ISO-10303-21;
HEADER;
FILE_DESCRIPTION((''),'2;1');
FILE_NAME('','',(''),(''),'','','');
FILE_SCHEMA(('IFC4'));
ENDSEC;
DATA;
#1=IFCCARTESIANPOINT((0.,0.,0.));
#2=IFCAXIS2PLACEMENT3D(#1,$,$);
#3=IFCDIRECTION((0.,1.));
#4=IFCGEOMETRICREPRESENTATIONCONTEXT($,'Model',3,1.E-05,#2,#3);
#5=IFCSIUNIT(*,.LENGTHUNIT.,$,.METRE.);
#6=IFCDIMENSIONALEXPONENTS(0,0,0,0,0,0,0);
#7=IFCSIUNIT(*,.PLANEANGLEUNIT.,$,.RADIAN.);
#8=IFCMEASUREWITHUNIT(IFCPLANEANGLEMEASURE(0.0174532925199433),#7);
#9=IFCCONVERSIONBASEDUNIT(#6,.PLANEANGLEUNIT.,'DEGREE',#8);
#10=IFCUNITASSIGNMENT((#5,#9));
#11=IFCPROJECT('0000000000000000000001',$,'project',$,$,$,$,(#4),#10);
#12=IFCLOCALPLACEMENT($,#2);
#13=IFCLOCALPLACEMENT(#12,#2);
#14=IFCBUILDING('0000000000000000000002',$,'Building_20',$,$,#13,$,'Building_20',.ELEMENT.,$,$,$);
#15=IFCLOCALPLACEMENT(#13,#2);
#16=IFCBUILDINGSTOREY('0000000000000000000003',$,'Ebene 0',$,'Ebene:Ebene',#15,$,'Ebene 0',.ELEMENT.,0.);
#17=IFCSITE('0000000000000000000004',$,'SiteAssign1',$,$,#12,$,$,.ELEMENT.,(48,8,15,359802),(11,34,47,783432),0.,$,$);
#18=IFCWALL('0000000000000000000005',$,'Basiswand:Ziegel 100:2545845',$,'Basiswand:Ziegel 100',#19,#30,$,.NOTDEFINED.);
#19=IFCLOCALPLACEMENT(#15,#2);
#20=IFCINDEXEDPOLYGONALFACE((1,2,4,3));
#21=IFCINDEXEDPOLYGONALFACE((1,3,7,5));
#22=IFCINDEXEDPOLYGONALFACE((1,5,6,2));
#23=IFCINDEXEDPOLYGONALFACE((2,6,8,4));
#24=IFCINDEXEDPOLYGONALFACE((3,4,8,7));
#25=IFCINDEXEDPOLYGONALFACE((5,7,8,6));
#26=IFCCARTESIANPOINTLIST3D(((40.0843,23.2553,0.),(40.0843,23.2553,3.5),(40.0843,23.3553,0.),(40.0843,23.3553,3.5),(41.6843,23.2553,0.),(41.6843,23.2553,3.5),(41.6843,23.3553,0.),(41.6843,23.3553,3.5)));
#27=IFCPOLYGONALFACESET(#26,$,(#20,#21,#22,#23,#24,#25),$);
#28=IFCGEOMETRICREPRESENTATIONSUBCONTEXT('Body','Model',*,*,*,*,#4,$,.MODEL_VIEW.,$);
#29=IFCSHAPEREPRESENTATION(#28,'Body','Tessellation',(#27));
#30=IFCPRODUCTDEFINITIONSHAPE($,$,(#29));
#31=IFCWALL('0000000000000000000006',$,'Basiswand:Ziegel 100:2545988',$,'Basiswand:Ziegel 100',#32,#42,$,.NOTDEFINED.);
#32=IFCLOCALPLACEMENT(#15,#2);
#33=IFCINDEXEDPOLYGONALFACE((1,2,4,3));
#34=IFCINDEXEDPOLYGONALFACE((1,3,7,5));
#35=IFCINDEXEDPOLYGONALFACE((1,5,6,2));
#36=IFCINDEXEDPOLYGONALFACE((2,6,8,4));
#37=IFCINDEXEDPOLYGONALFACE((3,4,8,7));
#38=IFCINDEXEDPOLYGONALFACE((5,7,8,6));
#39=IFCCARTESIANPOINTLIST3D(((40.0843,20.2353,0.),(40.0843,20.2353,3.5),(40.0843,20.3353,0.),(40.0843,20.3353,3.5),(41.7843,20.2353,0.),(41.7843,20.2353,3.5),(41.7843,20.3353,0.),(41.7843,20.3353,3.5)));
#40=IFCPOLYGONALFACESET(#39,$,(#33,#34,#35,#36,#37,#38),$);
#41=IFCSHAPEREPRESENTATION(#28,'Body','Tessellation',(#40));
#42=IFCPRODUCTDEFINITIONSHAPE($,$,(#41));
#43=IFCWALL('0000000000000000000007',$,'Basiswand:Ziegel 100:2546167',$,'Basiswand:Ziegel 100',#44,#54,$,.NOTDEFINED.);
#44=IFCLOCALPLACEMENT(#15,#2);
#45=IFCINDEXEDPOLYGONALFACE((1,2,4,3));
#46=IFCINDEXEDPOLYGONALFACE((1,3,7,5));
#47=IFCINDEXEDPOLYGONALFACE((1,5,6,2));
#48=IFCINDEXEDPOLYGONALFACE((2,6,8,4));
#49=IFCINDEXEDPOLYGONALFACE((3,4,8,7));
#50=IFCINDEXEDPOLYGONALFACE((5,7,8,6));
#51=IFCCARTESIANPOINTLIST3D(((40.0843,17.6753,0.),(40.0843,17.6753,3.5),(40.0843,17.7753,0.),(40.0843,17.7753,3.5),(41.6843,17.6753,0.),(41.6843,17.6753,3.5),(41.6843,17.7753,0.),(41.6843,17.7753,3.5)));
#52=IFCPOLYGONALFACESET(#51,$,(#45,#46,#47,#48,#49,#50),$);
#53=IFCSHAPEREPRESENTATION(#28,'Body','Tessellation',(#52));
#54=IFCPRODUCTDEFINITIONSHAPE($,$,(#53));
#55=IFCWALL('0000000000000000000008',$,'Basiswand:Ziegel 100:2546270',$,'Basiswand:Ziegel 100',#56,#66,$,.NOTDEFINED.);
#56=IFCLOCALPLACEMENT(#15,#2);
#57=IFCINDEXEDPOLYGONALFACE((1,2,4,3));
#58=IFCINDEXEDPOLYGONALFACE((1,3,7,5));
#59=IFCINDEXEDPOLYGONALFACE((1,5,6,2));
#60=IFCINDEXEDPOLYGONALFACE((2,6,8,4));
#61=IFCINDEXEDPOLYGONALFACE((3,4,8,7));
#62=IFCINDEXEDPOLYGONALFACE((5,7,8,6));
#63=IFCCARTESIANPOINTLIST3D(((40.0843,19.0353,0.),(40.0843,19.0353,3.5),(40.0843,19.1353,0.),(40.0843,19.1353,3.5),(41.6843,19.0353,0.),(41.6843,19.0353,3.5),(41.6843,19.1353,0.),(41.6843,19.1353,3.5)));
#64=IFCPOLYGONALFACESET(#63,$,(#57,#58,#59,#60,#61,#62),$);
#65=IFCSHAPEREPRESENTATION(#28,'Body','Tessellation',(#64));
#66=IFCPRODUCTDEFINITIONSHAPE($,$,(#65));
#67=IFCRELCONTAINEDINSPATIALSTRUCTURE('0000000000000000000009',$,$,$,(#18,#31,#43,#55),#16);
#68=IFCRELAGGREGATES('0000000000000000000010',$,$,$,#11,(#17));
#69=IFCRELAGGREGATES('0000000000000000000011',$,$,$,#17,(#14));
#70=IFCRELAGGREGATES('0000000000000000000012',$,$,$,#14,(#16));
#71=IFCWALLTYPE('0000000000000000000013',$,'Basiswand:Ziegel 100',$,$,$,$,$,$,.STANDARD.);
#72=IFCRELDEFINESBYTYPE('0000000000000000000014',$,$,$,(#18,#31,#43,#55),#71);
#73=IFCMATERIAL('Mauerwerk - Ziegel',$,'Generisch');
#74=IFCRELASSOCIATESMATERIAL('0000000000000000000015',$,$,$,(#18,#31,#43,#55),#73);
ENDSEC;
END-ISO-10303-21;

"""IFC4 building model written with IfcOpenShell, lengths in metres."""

from ifc_helpers import new_model, entity, si_unit, converted_unit, direction, frame, origin, place, context, subcontext, project, spatial, indexed_curve, outline, extrude, material, type_object, element, save


model = new_model("IFC4")

# Units and contexts
model_context = context("Model", 3, precision=1e-05, world=origin(), true_north=direction((0.0, 1.0)))
body_context = subcontext(model_context, "Body", "Model", "MODEL_VIEW")
ifc_project = project(units=[si_unit("LENGTHUNIT", "METRE"), converted_unit("PLANEANGLEUNIT", "DEGREE", entity("IfcPlaneAngleMeasure", 0.0174532925199433), si_unit("PLANEANGLEUNIT", "RADIAN"), dimensions=[0, 0, 0, 0, 0, 0, 0])], contexts=[model_context])

# Site, building, storey
site_placement = place(None, origin())
site = spatial("IfcSite", under=ifc_project, at=site_placement, Name="SiteAssign1", CompositionType="ELEMENT", RefLatitude=(48, 8, 15, 359802), RefLongitude=(11, 34, 47, 783432), RefElevation=0.0)
building_placement = place(site_placement, origin())
building = spatial("IfcBuilding", under=site, at=building_placement, Name="Building_20", LongName="Building_20", CompositionType="ELEMENT")
storey_placement = place(building_placement, origin())
storey = spatial("IfcBuildingStorey", under=building, at=storey_placement, Name="Ebene 0", ObjectType="Ebene:Ebene", LongName="Ebene 0", CompositionType="ELEMENT", Elevation=0.0)

# Shared definitions
ifc_material_1 = material(Name="Mauerwerk - Ziegel", Category="Generisch")

# Walls
wall_type_1 = type_object("IfcWallType", Name="Basiswand:Ziegel 100", PredefinedType="STANDARD")
wall_1_placement = place(storey_placement, frame((40.0843, 23.3053, 0.0)))
element("IfcWall", 1, at=wall_1_placement, inside=storey, type_object=wall_type_1, material=ifc_material_1, Name="Basiswand:Ziegel 100:2545845", ObjectType="Basiswand:Ziegel 100", PredefinedType="NOTDEFINED", context=body_context, shape_type="SweptSolid", body=[
    extrude(outline(indexed_curve([(1.6, 0.05), (0.0, 0.05), (0.0, -0.05), (1.6, -0.05), (1.6, 0.05)], self_intersect=False)), origin(), (0.0, 0.0, 1.0), 3.5),
])
wall_2_placement = place(storey_placement, frame((40.0843, 20.2853, 0.0)))
element("IfcWall", 2, at=wall_2_placement, inside=storey, type_object=wall_type_1, material=ifc_material_1, Name="Basiswand:Ziegel 100:2545988", ObjectType="Basiswand:Ziegel 100", PredefinedType="NOTDEFINED", context=body_context, shape_type="SweptSolid", body=[
    extrude(outline(indexed_curve([(1.7, 0.05), (0.0, 0.05), (0.0, -0.05), (1.7, -0.05), (1.7, 0.05)], self_intersect=False)), origin(), (0.0, 0.0, 1.0), 3.5),
])
for number, where, name in (
    (3, (40.0843, 17.7253, 0.0), "Basiswand:Ziegel 100:2546167"),
    (4, (40.0843, 19.0853, 0.0), "Basiswand:Ziegel 100:2546270"),
):
    element("IfcWall", number, at=place(storey_placement, frame(where)), inside=storey, type_object=wall_type_1, material=ifc_material_1, Name=name, ObjectType="Basiswand:Ziegel 100", PredefinedType="NOTDEFINED", context=body_context, shape_type="SweptSolid", body=[
        extrude(outline(indexed_curve([(1.6, 0.05), (0.0, 0.05), (0.0, -0.05), (1.6, -0.05), (1.6, 0.05)], self_intersect=False)), origin(), (0.0, 0.0, 1.0), 3.5),
    ])

save(model, "model.ifc")
